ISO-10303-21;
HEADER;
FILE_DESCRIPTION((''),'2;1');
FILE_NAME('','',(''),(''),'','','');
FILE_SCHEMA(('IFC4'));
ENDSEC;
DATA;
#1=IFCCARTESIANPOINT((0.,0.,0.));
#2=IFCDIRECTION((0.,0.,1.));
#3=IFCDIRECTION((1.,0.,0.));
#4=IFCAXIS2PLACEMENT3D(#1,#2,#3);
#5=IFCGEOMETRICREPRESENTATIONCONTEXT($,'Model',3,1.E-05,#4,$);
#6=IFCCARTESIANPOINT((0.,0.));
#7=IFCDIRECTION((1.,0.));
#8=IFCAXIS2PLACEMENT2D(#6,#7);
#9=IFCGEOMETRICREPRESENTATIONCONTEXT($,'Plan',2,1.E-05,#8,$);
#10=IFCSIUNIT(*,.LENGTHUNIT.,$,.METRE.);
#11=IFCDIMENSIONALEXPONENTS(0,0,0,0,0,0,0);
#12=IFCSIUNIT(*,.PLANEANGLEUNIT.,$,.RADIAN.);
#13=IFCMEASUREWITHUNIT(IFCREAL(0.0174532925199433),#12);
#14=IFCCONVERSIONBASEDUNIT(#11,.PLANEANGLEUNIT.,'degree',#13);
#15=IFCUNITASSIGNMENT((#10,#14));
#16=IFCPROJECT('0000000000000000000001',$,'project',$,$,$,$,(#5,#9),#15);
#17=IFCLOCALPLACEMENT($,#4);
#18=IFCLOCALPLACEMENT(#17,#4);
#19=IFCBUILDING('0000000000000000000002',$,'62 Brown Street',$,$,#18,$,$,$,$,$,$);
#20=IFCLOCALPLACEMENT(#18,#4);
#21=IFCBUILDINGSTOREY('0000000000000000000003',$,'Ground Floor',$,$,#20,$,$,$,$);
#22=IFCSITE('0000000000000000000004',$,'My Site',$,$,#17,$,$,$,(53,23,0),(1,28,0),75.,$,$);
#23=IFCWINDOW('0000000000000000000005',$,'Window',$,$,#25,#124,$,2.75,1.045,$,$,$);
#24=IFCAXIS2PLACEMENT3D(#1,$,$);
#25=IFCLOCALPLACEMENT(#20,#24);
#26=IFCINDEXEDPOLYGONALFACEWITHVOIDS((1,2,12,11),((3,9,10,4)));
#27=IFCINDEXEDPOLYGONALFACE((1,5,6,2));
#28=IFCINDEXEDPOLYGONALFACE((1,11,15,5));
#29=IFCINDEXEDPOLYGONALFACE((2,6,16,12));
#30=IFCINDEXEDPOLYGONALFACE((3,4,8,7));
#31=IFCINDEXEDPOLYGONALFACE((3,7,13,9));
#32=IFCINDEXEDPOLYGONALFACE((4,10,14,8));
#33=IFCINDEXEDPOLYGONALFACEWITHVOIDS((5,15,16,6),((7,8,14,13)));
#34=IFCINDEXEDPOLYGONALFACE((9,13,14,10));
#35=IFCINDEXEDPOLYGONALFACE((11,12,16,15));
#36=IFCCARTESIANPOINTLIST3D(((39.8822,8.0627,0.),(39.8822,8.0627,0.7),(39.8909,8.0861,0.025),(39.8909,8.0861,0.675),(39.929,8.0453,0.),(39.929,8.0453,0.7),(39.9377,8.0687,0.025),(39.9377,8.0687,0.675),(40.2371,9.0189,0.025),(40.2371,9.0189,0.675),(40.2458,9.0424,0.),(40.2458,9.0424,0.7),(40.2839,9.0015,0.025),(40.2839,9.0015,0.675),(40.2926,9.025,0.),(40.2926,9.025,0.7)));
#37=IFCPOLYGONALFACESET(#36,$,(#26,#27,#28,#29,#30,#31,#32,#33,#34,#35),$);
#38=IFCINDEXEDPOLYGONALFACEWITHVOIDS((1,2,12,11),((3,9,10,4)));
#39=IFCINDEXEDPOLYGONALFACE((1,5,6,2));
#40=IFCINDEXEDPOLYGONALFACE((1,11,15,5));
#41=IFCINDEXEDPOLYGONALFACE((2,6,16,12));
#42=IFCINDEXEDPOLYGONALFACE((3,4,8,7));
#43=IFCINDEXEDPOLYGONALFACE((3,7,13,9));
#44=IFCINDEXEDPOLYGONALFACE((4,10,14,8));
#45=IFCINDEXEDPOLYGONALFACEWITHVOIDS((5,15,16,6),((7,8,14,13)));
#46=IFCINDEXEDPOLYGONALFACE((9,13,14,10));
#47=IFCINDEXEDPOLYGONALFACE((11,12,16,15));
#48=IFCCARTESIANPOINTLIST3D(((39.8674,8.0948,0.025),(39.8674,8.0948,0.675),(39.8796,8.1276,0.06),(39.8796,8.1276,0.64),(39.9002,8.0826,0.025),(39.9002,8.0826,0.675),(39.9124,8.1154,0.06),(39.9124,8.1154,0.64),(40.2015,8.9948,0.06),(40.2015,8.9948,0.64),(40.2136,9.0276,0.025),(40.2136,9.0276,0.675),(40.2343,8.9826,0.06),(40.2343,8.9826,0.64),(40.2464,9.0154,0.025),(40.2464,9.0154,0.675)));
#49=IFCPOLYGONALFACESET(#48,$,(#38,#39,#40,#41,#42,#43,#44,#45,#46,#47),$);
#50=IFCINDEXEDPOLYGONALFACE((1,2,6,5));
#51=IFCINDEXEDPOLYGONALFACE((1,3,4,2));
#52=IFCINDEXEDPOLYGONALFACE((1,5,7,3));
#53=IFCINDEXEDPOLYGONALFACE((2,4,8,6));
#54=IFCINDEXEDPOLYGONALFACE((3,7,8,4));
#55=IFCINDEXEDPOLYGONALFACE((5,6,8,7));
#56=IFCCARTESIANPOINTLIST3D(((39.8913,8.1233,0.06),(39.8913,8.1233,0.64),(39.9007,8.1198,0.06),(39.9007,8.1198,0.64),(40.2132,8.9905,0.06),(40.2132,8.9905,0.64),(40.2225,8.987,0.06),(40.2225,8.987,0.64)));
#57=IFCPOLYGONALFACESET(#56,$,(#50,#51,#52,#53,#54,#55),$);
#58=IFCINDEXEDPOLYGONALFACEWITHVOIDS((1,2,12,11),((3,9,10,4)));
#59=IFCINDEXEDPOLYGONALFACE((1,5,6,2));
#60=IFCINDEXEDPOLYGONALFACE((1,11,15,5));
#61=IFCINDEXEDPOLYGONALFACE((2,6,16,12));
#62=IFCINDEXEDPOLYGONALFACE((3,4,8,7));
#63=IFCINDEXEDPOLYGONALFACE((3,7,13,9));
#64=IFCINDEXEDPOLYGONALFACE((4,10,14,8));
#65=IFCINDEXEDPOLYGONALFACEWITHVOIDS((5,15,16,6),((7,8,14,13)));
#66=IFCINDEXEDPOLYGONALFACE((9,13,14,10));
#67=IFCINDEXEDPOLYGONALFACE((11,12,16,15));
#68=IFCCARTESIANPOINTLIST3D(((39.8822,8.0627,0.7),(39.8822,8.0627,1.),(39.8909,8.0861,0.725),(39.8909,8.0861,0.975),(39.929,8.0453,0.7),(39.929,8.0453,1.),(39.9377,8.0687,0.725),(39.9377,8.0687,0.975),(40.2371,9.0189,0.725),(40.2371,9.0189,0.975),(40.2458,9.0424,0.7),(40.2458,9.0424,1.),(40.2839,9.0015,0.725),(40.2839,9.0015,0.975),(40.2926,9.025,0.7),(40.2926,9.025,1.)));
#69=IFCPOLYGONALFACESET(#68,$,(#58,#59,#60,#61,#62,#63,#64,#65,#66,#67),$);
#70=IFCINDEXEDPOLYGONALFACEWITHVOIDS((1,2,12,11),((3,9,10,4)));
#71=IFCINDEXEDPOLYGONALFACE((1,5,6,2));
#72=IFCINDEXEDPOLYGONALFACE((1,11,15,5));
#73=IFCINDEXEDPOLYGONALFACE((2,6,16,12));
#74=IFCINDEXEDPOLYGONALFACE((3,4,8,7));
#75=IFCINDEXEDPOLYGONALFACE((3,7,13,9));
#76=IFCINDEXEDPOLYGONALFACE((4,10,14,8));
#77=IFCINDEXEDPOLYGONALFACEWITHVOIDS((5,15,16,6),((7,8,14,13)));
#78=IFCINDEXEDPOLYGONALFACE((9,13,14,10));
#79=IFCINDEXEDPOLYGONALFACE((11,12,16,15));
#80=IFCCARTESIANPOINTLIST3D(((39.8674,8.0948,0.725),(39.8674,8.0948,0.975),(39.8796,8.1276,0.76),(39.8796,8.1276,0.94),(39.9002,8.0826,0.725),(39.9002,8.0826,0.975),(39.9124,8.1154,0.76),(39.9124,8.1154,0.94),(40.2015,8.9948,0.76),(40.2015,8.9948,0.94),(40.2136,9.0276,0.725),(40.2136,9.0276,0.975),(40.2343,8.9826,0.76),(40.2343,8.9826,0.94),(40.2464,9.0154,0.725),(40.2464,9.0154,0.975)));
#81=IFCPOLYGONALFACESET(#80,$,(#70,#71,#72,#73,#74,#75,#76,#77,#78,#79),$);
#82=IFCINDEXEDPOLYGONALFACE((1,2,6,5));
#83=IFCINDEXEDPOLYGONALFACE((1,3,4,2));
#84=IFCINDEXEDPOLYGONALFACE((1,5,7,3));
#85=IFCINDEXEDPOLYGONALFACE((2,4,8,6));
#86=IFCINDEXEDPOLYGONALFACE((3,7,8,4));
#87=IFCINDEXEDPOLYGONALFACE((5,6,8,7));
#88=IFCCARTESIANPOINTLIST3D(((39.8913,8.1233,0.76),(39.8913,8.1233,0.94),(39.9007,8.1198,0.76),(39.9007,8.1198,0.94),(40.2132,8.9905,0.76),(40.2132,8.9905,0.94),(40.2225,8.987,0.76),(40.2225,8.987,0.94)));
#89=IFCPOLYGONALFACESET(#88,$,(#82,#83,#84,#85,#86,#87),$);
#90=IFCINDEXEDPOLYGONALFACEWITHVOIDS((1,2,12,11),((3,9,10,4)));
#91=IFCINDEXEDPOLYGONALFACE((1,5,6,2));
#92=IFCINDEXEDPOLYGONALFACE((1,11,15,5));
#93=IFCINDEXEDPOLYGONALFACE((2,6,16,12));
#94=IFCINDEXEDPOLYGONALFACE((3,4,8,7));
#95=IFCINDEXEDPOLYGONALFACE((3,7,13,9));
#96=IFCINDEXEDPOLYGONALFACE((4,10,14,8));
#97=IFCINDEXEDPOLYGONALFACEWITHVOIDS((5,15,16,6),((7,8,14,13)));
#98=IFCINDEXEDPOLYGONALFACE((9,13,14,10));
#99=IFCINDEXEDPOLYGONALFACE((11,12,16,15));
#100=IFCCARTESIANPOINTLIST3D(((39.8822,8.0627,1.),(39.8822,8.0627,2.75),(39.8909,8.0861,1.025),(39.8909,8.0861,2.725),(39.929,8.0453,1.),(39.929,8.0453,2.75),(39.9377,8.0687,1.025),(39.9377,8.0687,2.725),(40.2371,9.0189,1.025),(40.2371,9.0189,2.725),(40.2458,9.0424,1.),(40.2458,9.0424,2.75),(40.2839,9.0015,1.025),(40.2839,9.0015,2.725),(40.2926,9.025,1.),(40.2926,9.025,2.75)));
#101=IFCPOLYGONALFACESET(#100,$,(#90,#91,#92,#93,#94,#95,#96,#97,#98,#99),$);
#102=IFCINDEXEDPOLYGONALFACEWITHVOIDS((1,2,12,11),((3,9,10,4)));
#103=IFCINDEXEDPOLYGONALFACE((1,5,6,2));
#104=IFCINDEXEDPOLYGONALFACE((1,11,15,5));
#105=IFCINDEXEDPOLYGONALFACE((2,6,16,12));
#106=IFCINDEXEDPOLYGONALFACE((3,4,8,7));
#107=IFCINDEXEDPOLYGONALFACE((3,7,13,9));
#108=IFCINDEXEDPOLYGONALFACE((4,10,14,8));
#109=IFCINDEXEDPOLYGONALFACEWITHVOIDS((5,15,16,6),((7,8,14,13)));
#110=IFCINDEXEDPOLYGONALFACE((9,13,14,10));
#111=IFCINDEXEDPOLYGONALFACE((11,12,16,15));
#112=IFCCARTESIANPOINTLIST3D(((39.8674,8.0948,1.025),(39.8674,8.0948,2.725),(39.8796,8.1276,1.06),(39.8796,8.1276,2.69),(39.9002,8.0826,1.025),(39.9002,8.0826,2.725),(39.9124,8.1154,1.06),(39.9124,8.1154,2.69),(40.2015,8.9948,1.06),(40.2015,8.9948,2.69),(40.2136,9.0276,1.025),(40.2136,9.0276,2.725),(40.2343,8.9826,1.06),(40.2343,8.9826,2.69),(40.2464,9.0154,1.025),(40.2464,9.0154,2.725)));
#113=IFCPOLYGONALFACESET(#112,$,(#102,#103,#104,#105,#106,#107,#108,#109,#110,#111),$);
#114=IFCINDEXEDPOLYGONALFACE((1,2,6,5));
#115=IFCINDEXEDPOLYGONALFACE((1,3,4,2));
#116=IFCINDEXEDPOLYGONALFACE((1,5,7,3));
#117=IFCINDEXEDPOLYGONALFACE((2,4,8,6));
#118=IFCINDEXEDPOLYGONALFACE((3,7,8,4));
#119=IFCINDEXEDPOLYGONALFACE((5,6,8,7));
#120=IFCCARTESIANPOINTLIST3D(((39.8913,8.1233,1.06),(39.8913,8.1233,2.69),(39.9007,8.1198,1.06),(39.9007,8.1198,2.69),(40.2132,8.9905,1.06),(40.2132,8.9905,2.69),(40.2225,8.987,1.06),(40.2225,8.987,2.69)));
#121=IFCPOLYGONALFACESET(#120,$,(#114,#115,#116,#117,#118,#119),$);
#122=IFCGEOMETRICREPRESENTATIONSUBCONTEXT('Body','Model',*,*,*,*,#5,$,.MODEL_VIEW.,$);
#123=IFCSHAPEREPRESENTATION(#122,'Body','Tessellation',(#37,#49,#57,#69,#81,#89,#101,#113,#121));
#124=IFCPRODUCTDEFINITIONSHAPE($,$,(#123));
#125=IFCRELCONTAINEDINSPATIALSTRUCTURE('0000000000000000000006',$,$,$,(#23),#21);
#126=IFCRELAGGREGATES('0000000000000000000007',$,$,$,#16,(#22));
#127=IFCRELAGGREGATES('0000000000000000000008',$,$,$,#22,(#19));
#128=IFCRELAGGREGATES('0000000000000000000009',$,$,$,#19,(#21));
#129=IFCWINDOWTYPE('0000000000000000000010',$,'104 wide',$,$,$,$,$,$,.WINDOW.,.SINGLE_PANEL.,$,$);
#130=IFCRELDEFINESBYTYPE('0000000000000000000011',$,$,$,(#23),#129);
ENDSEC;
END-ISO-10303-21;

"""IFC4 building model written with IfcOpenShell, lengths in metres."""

from ifc_helpers import new_model, entity, si_unit, converted_unit, frame, origin_with_axes, origin_2d_with_axis, place, context, subcontext, project, spatial, line, indexed_curve, outline, extrude, shape, source, transform, mapped, type_object, type_shapes, element, save


model = new_model("IFC4")

# Units and contexts
model_context = context("Model", 3, precision=1e-05, world=origin_with_axes())
plan_context = context("Plan", 2, precision=1e-05, world=origin_2d_with_axis())
body_context_1 = subcontext(model_context, "Body", "Model", "MODEL_VIEW")
body_context_2 = subcontext(plan_context, "Body", "Plan", "PLAN_VIEW")
ifc_project = project(units=[si_unit("LENGTHUNIT", "METRE"), converted_unit("PLANEANGLEUNIT", "degree", entity("IfcReal", 0.0174532925199433), si_unit("PLANEANGLEUNIT", "RADIAN"), dimensions=[0, 0, 0, 0, 0, 0, 0])], contexts=[model_context, plan_context])

# Site, building, storey
site_placement = place(None, origin_with_axes())
site = spatial("IfcSite", under=ifc_project, at=site_placement, Name="My Site", RefLatitude=(53, 23, 0), RefLongitude=(1, 28, 0), RefElevation=75.0)
building_placement = place(site_placement, origin_with_axes())
building = spatial("IfcBuilding", under=site, at=building_placement, Name="62 Brown Street")
storey_placement = place(building_placement, origin_with_axes())
storey = spatial("IfcBuildingStorey", under=building, at=storey_placement, Name="Ground Floor")

# Window
window_type_1 = type_object("IfcWindowType", Name="104 wide", PartitioningType="SINGLE_PANEL", PredefinedType="WINDOW")
shared_shape_1 = source(origin_with_axes(), body_context_1, "Body", "SweptSolid", [
    extrude(outline(indexed_curve([(0.0, 0.0), (1.045, 0.0), (1.045, 0.7), (0.0, 0.7)], segments=[line(1, 2, 3, 4, 1)]), holes=[indexed_curve([(0.025, 0.025), (1.02, 0.025), (1.02, 0.675), (0.025, 0.675)], segments=[line(1, 2, 3, 4, 1)])]), frame((0.0, 0.15, 0.0), z_axis=(0.0, -1.0, 0.0), x_axis=(1.0, 0.0, 0.0)), (0.0, 0.0, -1.0), 0.05),
    extrude(outline(indexed_curve([(0.0, 0.0), (0.995, 0.0), (0.995, 0.65), (0.0, 0.65)], segments=[line(1, 2, 3, 4, 1)]), holes=[indexed_curve([(0.035, 0.035), (0.96, 0.035), (0.96, 0.615), (0.035, 0.615)], segments=[line(1, 2, 3, 4, 1)])]), frame((0.025, 0.19, 0.025), z_axis=(0.0, -1.0, 0.0), x_axis=(1.0, 0.0, 0.0)), (0.0, 0.0, -1.0), 0.035),
    extrude(outline(indexed_curve([(0.035, 0.035), (0.96, 0.035), (0.96, 0.615), (0.035, 0.615)], segments=[line(1, 2, 3, 4, 1)])), frame((0.025, 0.2025, 0.025), z_axis=(0.0, -1.0, 0.0), x_axis=(1.0, 0.0, 0.0)), (0.0, 0.0, -1.0), 0.01),
    extrude(outline(indexed_curve([(0.0, 0.0), (1.045, 0.0), (1.045, 0.3), (0.0, 0.3)], segments=[line(1, 2, 3, 4, 1)]), holes=[indexed_curve([(0.025, 0.025), (1.02, 0.025), (1.02, 0.275), (0.025, 0.275)], segments=[line(1, 2, 3, 4, 1)])]), frame((0.0, 0.15, 0.7), z_axis=(0.0, -1.0, 0.0), x_axis=(1.0, 0.0, 0.0)), (0.0, 0.0, -1.0), 0.05),
    extrude(outline(indexed_curve([(0.0, 0.0), (0.995, 0.0), (0.995, 0.25), (0.0, 0.25)], segments=[line(1, 2, 3, 4, 1)]), holes=[indexed_curve([(0.035, 0.035), (0.96, 0.035), (0.96, 0.215), (0.035, 0.215)], segments=[line(1, 2, 3, 4, 1)])]), frame((0.025, 0.19, 0.725), z_axis=(0.0, -1.0, 0.0), x_axis=(1.0, 0.0, 0.0)), (0.0, 0.0, -1.0), 0.035),
    extrude(outline(indexed_curve([(0.035, 0.035), (0.96, 0.035), (0.96, 0.215), (0.035, 0.215)], segments=[line(1, 2, 3, 4, 1)])), frame((0.025, 0.2025, 0.725), z_axis=(0.0, -1.0, 0.0), x_axis=(1.0, 0.0, 0.0)), (0.0, 0.0, -1.0), 0.01),
    extrude(outline(indexed_curve([(0.0, 0.0), (1.045, 0.0), (1.045, 1.75), (0.0, 1.75)], segments=[line(1, 2, 3, 4, 1)]), holes=[indexed_curve([(0.025, 0.025), (1.02, 0.025), (1.02, 1.725), (0.025, 1.725)], segments=[line(1, 2, 3, 4, 1)])]), frame((0.0, 0.15, 1.0), z_axis=(0.0, -1.0, 0.0), x_axis=(1.0, 0.0, 0.0)), (0.0, 0.0, -1.0), 0.05),
    extrude(outline(indexed_curve([(0.0, 0.0), (0.995, 0.0), (0.995, 1.7), (0.0, 1.7)], segments=[line(1, 2, 3, 4, 1)]), holes=[indexed_curve([(0.035, 0.035), (0.96, 0.035), (0.96, 1.665), (0.035, 1.665)], segments=[line(1, 2, 3, 4, 1)])]), frame((0.025, 0.19, 1.025), z_axis=(0.0, -1.0, 0.0), x_axis=(1.0, 0.0, 0.0)), (0.0, 0.0, -1.0), 0.035),
    extrude(outline(indexed_curve([(0.035, 0.035), (0.96, 0.035), (0.96, 1.665), (0.035, 1.665)], segments=[line(1, 2, 3, 4, 1)])), frame((0.025, 0.2025, 1.025), z_axis=(0.0, -1.0, 0.0), x_axis=(1.0, 0.0, 0.0)), (0.0, 0.0, -1.0), 0.01),
])
shared_shape_2 = source(origin_with_axes(), body_context_2, "Body", "Curve2D", [
    entity("IfcIndexedPolyCurve", entity("IfcCartesianPointList2D", [[0.025, 0.15], [1.02, 0.15]])),
    entity("IfcIndexedPolyCurve", entity("IfcCartesianPointList2D", [[0.0, 0.2], [0.025, 0.2], [0.025, 0.15], [0.0, 0.15]]), [entity("IfcLineIndex", [1, 2, 3, 4, 1])]),
    entity("IfcIndexedPolyCurve", entity("IfcCartesianPointList2D", [[1.045, 0.2], [1.02, 0.2], [1.02, 0.15], [1.045, 0.15]]), [entity("IfcLineIndex", [1, 2, 3, 4, 1])]),
    entity("IfcIndexedPolyCurve", entity("IfcCartesianPointList2D", [[0.025, 0.19], [0.06, 0.19], [0.06, 0.225], [0.025, 0.225]]), [entity("IfcLineIndex", [1, 2, 3, 4, 1])]),
    entity("IfcIndexedPolyCurve", entity("IfcCartesianPointList2D", [[1.02, 0.19], [0.985, 0.19], [0.985, 0.225], [1.02, 0.225]]), [entity("IfcLineIndex", [1, 2, 3, 4, 1])]),
    entity("IfcIndexedPolyCurve", entity("IfcCartesianPointList2D", [[0.06, 0.19], [0.985, 0.19]])),
    entity("IfcIndexedPolyCurve", entity("IfcCartesianPointList2D", [[0.06, 0.225], [0.985, 0.225]])),
    entity("IfcIndexedPolyCurve", entity("IfcCartesianPointList2D", [[0.06, 0.2075], [0.985, 0.2075]])),
])
type_shapes(window_type_1, [shared_shape_1, shared_shape_2])
placement_1 = place(storey_placement, frame((39.024, 5.1755, 0.0), z_axis=(0.0, 0.0, 1.0), x_axis=(0.347944, 0.937515, 0.0)))
placement_2 = place(placement_1, frame((3.0054, 0.0, 0.0), z_axis=(0.0, 0.0, 1.0), x_axis=(1.0, 0.0, 0.0)))
window_1_placement = place(placement_2, frame((0.0, 0.0, 0.0), z_axis=(0.0, 0.0, 1.0), x_axis=(1.0, 0.0, 0.0)))
element("IfcWindow", 1, at=window_1_placement, inside=storey, type_object=window_type_1, Name="Window", OverallHeight=2.75, OverallWidth=1.045, shapes=[
    shape(body_context_1, "Body", "MappedRepresentation", [mapped(shared_shape_1, transform((0.0, 0.0, 0.0), x_axis=(1.0, 0.0, 0.0), y_axis=(0.0, 1.0, 0.0), z_axis=(0.0, 0.0, 1.0), scale=1.0))]),
    shape(body_context_2, "Body", "MappedRepresentation", [mapped(shared_shape_2, transform((0.0, 0.0, 0.0), x_axis=(1.0, 0.0, 0.0), y_axis=(0.0, 1.0, 0.0), z_axis=(0.0, 0.0, 1.0), scale=1.0))]),
])

save(model, "model.ifc")
